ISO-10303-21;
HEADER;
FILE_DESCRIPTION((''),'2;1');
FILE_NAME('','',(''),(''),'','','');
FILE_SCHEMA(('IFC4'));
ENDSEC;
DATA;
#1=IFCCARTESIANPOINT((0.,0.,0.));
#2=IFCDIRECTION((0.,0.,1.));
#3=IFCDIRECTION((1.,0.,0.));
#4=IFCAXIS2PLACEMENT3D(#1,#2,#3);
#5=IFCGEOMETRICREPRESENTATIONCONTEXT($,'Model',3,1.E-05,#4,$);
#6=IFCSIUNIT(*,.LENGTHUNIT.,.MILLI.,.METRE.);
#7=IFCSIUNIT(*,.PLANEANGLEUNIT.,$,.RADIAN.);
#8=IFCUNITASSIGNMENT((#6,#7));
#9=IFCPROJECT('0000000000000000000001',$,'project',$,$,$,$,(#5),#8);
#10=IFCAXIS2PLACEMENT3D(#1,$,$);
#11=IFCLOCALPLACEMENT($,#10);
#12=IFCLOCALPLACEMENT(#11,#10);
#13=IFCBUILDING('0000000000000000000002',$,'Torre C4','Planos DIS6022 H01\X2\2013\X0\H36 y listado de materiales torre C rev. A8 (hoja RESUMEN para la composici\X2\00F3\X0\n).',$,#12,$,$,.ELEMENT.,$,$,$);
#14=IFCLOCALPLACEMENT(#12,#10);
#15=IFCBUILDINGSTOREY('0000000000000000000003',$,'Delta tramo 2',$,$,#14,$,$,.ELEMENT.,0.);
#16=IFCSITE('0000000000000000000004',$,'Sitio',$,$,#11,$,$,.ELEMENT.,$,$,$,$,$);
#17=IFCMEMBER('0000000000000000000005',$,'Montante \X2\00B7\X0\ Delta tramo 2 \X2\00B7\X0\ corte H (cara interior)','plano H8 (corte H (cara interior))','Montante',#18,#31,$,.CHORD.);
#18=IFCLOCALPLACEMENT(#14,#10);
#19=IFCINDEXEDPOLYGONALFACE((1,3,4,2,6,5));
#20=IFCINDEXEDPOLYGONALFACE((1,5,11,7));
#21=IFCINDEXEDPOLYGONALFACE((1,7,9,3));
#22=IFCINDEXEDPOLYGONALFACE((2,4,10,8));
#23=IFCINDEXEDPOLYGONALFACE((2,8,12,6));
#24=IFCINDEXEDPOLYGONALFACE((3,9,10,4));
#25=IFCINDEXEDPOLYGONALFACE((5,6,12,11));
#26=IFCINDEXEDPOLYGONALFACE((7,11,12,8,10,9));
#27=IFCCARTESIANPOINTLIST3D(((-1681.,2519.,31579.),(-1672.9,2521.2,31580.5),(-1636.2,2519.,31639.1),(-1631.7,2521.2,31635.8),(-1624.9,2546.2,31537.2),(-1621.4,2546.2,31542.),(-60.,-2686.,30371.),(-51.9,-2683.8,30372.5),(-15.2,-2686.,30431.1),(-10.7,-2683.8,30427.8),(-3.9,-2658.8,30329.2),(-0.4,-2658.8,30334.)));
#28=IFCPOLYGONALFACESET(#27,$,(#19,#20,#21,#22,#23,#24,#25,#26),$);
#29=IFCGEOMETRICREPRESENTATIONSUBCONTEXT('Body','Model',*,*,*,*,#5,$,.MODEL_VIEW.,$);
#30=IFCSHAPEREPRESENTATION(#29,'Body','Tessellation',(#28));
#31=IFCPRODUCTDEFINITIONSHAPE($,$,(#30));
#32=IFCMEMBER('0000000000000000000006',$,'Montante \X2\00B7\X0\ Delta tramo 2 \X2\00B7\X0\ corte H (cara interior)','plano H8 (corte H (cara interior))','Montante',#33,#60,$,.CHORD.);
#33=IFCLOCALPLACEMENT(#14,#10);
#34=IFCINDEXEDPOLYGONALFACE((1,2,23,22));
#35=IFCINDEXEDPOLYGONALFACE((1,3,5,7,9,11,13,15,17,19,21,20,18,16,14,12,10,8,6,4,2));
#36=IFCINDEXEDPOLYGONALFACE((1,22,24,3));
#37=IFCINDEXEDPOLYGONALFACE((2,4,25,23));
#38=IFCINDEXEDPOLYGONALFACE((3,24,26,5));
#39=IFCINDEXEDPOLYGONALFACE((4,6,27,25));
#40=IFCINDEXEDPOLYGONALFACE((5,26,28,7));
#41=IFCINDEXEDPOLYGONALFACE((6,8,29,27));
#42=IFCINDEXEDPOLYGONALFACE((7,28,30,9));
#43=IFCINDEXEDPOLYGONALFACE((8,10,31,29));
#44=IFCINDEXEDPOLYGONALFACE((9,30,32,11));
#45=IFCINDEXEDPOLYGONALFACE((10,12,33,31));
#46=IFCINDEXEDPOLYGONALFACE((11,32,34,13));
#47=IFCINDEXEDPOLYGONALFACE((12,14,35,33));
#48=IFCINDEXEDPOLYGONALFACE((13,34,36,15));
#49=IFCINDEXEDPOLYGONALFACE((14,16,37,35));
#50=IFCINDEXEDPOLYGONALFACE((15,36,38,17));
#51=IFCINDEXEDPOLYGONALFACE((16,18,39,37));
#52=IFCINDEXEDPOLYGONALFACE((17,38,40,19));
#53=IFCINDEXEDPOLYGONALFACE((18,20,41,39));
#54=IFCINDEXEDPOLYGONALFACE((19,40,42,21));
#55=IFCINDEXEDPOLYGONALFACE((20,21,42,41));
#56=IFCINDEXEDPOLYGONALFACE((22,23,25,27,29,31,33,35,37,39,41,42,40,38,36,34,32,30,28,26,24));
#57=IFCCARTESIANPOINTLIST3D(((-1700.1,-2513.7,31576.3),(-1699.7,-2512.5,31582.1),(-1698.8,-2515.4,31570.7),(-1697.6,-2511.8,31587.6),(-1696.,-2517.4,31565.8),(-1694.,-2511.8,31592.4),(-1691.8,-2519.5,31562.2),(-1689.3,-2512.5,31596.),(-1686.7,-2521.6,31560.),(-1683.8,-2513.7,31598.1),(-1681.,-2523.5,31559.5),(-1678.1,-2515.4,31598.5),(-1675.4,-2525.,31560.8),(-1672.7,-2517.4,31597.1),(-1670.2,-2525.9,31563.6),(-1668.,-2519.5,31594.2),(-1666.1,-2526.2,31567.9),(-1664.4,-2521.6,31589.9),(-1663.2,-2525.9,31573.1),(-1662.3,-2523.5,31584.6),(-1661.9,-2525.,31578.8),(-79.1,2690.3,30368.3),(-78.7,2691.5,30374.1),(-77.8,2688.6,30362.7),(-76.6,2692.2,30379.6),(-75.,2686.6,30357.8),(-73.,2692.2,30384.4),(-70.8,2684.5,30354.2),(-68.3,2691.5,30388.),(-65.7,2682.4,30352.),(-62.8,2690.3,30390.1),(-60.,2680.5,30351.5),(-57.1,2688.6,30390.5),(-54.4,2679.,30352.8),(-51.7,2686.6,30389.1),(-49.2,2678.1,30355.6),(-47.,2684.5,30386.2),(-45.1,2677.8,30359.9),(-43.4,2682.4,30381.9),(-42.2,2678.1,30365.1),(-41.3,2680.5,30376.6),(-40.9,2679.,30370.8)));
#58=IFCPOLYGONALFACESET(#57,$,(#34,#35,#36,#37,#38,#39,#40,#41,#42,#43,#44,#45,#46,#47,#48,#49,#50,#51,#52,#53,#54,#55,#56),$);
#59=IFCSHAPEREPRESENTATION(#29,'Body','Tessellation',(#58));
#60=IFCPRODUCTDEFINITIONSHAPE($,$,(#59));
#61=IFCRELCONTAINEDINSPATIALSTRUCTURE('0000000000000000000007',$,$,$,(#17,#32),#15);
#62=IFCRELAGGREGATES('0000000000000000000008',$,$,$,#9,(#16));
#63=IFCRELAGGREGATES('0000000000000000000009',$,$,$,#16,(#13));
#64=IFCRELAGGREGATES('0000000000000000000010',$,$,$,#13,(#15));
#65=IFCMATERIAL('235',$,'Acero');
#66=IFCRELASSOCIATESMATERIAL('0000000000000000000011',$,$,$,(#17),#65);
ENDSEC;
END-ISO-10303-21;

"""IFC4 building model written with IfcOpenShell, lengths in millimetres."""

from ifc_helpers import new_model, si_unit, frame, frame_2d, origin, origin_with_axes, place, context, subcontext, project, spatial, circle, l_section, extrude, material, element, save


model = new_model("IFC4")

# Units and contexts
model_context = context("Model", 3, precision=1e-05, world=origin_with_axes())
body_context = subcontext(model_context, "Body", "Model", "MODEL_VIEW")
ifc_project = project(units=[si_unit("LENGTHUNIT", "METRE", prefix="MILLI"), si_unit("PLANEANGLEUNIT", "RADIAN")], contexts=[model_context])

# Site, building, storey
site_placement = place(None, origin())
site = spatial("IfcSite", under=ifc_project, at=site_placement, Name="Sitio", CompositionType="ELEMENT")
building_placement = place(site_placement, origin())
building = spatial("IfcBuilding", under=site, at=building_placement, Name="Torre C4", Description="Planos DIS6022 H01–H36 y listado de materiales torre C rev. A8 (hoja RESUMEN para la composición).", CompositionType="ELEMENT")
storey_placement = place(building_placement, origin())
storey = spatial("IfcBuildingStorey", under=building, at=storey_placement, Name="Delta tramo 2", CompositionType="ELEMENT", Elevation=0.0)

# Members
ifc_material = material(Name="235", Category="Acero")
member_1_placement = place(storey_placement, frame((-1681.0, 2519.0, 31579.0), z_axis=(0.290304, -0.932159, -0.21634), x_axis=(0.747439, 0.362048, -0.557006)))
element("IfcMember", 1, at=member_1_placement, inside=storey, material=ifc_material, Name="Montante · Delta tramo 2 · corte H (cara interior)", Description="plano H8 (corte H (cara interior))", ObjectType="Montante", PredefinedType="CHORD", context=body_context, shape_type="SweptSolid", body=[
    extrude(l_section(Depth=75.0, Width=75.0, Thickness=6.0, at=frame_2d((37.5, 37.5))), None, (0.0, 0.0, 1.0), 5583.8),
])
member_2_placement = place(storey_placement, frame((-60.0, 2685.0, 30371.0), z_axis=(-0.290352, -0.932136, 0.216376), x_axis=(0.74742, -0.362109, -0.556992)))
element("IfcMember", 2, at=member_2_placement, inside=storey, Name="Montante · Delta tramo 2 · corte H (cara interior)", Description="plano H8 (corte H (cara interior))", ObjectType="Montante", PredefinedType="CHORD", context=body_context, shape_type="SweptSolid", body=[
    extrude(circle(Radius=20.0), None, (0.0, 0.0, 1.0), 5582.9),
])

save(model, "model.ifc")
